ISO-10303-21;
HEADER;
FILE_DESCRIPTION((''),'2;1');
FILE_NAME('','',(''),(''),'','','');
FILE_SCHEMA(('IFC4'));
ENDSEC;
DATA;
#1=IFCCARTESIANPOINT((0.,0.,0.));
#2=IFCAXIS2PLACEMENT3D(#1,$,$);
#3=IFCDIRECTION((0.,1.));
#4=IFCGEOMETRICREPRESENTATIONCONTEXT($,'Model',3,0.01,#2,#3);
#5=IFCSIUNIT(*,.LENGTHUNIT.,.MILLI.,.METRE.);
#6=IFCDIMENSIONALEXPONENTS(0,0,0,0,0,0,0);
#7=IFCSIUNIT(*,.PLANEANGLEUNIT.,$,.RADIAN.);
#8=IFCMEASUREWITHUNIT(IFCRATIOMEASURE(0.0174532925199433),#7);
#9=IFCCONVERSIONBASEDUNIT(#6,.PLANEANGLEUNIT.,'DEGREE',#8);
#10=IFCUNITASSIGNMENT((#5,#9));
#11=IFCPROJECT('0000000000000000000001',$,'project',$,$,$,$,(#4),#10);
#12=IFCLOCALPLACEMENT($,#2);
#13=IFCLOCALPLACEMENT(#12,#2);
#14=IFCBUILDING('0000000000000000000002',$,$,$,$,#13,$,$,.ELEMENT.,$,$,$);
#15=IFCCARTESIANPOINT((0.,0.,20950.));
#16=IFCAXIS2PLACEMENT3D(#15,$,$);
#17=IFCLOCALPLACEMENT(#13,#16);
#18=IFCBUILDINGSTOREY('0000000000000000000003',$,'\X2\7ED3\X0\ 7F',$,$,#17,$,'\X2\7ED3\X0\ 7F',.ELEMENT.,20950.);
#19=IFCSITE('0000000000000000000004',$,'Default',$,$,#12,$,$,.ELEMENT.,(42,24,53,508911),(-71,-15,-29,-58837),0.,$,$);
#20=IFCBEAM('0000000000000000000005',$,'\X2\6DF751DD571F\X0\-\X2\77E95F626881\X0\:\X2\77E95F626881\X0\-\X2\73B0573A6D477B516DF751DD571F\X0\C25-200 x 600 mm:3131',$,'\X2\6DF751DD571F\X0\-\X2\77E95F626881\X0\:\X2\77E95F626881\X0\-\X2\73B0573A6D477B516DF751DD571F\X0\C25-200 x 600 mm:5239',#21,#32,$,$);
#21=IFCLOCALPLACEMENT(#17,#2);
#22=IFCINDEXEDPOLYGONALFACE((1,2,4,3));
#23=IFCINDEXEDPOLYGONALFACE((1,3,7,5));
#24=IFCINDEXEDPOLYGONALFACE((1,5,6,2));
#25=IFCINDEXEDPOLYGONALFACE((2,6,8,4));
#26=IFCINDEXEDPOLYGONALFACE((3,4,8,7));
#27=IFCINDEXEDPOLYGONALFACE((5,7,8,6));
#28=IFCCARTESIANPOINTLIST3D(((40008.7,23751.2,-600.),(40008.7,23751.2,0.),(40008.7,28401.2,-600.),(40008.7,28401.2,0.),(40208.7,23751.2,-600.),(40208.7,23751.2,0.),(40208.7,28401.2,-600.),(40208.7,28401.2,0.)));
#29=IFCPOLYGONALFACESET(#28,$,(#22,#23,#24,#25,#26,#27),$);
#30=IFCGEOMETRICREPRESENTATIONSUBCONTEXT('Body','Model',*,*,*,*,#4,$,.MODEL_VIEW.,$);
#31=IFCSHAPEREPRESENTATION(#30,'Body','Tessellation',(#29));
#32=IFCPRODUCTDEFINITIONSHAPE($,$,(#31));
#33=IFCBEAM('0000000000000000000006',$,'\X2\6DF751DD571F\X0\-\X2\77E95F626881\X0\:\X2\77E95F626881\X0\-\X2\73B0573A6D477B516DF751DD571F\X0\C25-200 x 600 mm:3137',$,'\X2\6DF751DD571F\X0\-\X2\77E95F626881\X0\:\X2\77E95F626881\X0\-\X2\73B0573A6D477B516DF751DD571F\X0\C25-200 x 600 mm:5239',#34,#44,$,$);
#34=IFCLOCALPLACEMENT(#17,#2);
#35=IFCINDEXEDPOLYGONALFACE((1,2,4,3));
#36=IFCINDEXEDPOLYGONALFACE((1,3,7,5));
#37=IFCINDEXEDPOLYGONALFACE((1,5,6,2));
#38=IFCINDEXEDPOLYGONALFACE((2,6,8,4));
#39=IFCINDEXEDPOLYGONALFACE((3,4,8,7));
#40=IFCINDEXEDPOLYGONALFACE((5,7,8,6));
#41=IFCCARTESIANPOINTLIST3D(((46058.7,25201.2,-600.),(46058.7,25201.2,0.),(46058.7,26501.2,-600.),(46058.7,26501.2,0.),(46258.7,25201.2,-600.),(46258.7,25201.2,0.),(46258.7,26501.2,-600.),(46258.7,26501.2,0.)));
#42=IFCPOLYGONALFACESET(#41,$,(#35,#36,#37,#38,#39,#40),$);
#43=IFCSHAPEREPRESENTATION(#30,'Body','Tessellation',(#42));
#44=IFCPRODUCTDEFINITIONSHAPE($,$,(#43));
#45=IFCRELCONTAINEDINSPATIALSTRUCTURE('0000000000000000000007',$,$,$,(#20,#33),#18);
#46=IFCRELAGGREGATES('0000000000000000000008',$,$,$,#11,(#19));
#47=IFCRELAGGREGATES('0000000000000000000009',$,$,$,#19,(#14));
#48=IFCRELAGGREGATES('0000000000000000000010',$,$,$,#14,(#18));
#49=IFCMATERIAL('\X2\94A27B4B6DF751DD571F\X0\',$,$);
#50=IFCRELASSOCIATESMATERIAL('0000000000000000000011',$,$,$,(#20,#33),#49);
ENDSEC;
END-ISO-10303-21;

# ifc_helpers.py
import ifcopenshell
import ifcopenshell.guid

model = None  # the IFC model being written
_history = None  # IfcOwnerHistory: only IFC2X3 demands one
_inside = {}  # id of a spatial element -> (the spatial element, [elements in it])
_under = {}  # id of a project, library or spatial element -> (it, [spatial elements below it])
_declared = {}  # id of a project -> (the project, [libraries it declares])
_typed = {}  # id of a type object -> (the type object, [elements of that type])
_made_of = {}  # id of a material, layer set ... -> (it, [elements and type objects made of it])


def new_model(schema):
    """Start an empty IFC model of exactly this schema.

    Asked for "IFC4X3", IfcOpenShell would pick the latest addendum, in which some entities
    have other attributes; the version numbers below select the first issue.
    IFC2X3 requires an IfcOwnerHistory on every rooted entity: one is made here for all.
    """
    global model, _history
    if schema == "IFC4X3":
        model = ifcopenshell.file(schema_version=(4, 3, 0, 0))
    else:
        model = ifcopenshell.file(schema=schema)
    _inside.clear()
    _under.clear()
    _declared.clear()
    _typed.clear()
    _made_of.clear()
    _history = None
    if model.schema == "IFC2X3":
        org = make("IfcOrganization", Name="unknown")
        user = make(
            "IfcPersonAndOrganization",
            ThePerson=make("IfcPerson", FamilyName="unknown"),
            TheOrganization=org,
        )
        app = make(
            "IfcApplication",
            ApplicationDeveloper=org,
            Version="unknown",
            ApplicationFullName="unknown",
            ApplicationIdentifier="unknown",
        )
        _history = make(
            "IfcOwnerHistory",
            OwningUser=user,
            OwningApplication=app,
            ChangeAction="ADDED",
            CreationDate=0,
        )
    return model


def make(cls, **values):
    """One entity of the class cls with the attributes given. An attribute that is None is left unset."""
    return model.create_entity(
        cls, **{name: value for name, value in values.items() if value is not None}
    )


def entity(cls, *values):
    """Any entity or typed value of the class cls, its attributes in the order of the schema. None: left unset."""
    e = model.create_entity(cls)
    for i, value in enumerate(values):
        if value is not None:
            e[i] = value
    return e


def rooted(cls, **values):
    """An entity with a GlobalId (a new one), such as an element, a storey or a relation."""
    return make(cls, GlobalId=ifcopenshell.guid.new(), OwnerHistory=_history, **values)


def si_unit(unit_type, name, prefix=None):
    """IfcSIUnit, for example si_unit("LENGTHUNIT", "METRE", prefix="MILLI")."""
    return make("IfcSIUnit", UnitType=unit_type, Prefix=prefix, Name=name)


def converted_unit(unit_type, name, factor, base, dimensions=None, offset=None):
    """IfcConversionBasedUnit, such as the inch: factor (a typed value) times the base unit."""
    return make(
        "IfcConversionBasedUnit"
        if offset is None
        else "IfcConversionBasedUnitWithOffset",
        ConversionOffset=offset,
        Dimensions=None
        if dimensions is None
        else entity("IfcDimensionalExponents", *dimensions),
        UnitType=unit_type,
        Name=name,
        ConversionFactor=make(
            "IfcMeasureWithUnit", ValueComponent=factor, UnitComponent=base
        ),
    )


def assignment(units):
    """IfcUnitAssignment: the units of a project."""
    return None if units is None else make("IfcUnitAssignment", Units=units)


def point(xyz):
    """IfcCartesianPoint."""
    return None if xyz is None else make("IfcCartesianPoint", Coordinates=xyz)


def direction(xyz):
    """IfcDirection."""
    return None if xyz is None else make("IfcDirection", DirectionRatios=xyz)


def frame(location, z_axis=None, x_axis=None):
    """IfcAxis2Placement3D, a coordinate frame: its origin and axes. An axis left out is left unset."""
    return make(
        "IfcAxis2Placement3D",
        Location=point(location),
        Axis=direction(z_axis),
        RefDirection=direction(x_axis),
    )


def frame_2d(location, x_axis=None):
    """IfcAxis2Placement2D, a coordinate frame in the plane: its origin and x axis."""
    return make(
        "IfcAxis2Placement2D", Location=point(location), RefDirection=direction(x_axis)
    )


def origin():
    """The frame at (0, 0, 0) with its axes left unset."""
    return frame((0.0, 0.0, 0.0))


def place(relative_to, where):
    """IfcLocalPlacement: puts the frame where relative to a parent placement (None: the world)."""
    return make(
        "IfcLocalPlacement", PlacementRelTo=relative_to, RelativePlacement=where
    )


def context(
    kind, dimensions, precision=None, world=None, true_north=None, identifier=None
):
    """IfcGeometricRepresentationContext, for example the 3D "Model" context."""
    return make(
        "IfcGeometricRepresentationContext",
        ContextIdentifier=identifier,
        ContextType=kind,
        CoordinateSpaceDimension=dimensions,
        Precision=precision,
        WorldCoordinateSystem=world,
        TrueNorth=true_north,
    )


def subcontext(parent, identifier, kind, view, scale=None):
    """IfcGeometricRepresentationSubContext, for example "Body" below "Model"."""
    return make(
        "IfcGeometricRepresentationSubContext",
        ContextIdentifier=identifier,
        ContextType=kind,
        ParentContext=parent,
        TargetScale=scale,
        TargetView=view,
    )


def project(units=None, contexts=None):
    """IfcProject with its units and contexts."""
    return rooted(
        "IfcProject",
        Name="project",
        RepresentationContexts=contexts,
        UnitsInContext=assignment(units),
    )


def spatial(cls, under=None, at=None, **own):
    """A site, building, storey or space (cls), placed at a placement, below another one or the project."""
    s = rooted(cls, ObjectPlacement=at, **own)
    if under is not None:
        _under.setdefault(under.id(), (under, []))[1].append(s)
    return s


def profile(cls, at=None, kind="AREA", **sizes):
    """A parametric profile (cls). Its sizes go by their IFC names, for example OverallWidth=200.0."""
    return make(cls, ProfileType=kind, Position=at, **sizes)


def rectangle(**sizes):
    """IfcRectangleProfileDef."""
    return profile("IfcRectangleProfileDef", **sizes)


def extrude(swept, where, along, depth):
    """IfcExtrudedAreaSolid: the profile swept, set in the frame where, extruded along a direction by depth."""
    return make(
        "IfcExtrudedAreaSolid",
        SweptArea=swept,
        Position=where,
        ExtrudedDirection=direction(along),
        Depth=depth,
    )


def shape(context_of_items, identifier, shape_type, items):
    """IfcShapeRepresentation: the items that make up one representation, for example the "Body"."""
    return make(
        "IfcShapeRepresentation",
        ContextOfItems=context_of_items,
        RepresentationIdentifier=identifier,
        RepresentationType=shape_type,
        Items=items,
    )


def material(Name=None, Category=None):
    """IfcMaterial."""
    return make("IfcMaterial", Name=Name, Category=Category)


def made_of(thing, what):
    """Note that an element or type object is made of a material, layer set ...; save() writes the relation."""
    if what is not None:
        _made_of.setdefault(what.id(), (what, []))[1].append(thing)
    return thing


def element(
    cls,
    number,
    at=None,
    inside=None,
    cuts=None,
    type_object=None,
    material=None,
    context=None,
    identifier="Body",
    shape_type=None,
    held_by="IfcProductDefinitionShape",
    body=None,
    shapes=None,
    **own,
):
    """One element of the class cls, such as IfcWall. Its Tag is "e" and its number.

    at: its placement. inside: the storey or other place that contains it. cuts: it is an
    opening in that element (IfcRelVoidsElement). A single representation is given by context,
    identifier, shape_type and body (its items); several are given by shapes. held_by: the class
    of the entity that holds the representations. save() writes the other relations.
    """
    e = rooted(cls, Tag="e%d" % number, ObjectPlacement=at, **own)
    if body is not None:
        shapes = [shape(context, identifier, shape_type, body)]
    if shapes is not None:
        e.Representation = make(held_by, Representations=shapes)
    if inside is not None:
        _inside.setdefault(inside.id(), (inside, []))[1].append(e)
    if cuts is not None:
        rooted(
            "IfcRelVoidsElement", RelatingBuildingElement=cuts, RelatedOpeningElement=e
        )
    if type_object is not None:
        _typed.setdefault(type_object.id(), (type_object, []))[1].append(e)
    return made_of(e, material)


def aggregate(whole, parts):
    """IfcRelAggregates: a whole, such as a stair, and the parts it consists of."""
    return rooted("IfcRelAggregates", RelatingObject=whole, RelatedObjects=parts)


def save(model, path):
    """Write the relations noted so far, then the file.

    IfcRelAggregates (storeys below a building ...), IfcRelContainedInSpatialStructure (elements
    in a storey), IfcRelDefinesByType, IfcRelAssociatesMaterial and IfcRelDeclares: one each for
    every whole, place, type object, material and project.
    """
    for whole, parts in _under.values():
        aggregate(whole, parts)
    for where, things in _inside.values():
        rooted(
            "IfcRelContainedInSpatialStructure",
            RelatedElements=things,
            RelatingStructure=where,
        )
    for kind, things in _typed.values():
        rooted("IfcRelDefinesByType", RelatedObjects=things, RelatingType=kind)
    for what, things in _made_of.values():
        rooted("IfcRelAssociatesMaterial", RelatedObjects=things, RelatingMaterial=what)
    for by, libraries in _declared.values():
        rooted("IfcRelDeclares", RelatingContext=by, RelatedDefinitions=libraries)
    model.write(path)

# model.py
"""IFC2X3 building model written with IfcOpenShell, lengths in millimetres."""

from ifc_helpers import new_model, entity, si_unit, converted_unit, direction, frame, frame_2d, origin, place, context, subcontext, project, spatial, rectangle, extrude, material, element, save


model = new_model("IFC2X3")

# Units and contexts
model_context = context("Model", 3, precision=0.01, world=origin(), true_north=direction((0.0, 1.0)))
body_context = subcontext(model_context, "Body", "Model", "MODEL_VIEW")
ifc_project = project(units=[si_unit("LENGTHUNIT", "METRE", prefix="MILLI"), converted_unit("PLANEANGLEUNIT", "DEGREE", entity("IfcRatioMeasure", 0.0174532925199433), si_unit("PLANEANGLEUNIT", "RADIAN"), dimensions=[0, 0, 0, 0, 0, 0, 0])], contexts=[model_context])

# Site, building, storey
site_placement = place(None, origin())
site = spatial("IfcSite", under=ifc_project, at=site_placement, Name="Default", CompositionType="ELEMENT", RefLatitude=(42, 24, 53, 508911), RefLongitude=(-71, -15, -29, -58837), RefElevation=0.0)
building_placement = place(site_placement, origin())
building = spatial("IfcBuilding", under=site, at=building_placement, CompositionType="ELEMENT")
storey_placement = place(building_placement, frame((0.0, 0.0, 20950.0)))
storey = spatial("IfcBuildingStorey", under=building, at=storey_placement, Name="结 7F", LongName="结 7F", CompositionType="ELEMENT", Elevation=20950.0)

# Beams
ifc_material = material(Name="钢筋混凝土")
beam_1_placement = place(storey_placement, frame((40108.7, 23551.2, 0.0), z_axis=(0.0, 0.0, 1.0), x_axis=(0.0, 1.0, 0.0)))
element("IfcBeam", 1, at=beam_1_placement, inside=storey, material=ifc_material, Name="混凝土-矩形梁:矩形梁-现场浇筑混凝土C25-200 x 600 mm:3131", ObjectType="混凝土-矩形梁:矩形梁-现场浇筑混凝土C25-200 x 600 mm:5239", context=body_context, shape_type="SweptSolid", body=[
    extrude(rectangle(XDim=600.0, YDim=200.0, at=frame_2d((0.0, 0.0), x_axis=(1.0, 0.0))), frame((200.0, 0.0, -300.0), z_axis=(1.0, 0.0, 0.0), x_axis=(0.0, 0.0, -1.0)), (0.0, 0.0, 1.0), 4650.0),
])
beam_2_placement = place(storey_placement, frame((46158.7, 25101.2, 0.0), z_axis=(0.0, 0.0, 1.0), x_axis=(0.0, 1.0, 0.0)))
element("IfcBeam", 2, at=beam_2_placement, inside=storey, material=ifc_material, Name="混凝土-矩形梁:矩形梁-现场浇筑混凝土C25-200 x 600 mm:3137", ObjectType="混凝土-矩形梁:矩形梁-现场浇筑混凝土C25-200 x 600 mm:5239", context=body_context, shape_type="SweptSolid", body=[
    extrude(rectangle(XDim=600.0, YDim=200.0, at=frame_2d((0.0, 0.0), x_axis=(1.0, 0.0))), frame((100.0, 0.0, -300.0), z_axis=(1.0, 0.0, 0.0), x_axis=(0.0, 0.0, -1.0)), (0.0, 0.0, 1.0), 1300.0),
])

save(model, "model.ifc")
